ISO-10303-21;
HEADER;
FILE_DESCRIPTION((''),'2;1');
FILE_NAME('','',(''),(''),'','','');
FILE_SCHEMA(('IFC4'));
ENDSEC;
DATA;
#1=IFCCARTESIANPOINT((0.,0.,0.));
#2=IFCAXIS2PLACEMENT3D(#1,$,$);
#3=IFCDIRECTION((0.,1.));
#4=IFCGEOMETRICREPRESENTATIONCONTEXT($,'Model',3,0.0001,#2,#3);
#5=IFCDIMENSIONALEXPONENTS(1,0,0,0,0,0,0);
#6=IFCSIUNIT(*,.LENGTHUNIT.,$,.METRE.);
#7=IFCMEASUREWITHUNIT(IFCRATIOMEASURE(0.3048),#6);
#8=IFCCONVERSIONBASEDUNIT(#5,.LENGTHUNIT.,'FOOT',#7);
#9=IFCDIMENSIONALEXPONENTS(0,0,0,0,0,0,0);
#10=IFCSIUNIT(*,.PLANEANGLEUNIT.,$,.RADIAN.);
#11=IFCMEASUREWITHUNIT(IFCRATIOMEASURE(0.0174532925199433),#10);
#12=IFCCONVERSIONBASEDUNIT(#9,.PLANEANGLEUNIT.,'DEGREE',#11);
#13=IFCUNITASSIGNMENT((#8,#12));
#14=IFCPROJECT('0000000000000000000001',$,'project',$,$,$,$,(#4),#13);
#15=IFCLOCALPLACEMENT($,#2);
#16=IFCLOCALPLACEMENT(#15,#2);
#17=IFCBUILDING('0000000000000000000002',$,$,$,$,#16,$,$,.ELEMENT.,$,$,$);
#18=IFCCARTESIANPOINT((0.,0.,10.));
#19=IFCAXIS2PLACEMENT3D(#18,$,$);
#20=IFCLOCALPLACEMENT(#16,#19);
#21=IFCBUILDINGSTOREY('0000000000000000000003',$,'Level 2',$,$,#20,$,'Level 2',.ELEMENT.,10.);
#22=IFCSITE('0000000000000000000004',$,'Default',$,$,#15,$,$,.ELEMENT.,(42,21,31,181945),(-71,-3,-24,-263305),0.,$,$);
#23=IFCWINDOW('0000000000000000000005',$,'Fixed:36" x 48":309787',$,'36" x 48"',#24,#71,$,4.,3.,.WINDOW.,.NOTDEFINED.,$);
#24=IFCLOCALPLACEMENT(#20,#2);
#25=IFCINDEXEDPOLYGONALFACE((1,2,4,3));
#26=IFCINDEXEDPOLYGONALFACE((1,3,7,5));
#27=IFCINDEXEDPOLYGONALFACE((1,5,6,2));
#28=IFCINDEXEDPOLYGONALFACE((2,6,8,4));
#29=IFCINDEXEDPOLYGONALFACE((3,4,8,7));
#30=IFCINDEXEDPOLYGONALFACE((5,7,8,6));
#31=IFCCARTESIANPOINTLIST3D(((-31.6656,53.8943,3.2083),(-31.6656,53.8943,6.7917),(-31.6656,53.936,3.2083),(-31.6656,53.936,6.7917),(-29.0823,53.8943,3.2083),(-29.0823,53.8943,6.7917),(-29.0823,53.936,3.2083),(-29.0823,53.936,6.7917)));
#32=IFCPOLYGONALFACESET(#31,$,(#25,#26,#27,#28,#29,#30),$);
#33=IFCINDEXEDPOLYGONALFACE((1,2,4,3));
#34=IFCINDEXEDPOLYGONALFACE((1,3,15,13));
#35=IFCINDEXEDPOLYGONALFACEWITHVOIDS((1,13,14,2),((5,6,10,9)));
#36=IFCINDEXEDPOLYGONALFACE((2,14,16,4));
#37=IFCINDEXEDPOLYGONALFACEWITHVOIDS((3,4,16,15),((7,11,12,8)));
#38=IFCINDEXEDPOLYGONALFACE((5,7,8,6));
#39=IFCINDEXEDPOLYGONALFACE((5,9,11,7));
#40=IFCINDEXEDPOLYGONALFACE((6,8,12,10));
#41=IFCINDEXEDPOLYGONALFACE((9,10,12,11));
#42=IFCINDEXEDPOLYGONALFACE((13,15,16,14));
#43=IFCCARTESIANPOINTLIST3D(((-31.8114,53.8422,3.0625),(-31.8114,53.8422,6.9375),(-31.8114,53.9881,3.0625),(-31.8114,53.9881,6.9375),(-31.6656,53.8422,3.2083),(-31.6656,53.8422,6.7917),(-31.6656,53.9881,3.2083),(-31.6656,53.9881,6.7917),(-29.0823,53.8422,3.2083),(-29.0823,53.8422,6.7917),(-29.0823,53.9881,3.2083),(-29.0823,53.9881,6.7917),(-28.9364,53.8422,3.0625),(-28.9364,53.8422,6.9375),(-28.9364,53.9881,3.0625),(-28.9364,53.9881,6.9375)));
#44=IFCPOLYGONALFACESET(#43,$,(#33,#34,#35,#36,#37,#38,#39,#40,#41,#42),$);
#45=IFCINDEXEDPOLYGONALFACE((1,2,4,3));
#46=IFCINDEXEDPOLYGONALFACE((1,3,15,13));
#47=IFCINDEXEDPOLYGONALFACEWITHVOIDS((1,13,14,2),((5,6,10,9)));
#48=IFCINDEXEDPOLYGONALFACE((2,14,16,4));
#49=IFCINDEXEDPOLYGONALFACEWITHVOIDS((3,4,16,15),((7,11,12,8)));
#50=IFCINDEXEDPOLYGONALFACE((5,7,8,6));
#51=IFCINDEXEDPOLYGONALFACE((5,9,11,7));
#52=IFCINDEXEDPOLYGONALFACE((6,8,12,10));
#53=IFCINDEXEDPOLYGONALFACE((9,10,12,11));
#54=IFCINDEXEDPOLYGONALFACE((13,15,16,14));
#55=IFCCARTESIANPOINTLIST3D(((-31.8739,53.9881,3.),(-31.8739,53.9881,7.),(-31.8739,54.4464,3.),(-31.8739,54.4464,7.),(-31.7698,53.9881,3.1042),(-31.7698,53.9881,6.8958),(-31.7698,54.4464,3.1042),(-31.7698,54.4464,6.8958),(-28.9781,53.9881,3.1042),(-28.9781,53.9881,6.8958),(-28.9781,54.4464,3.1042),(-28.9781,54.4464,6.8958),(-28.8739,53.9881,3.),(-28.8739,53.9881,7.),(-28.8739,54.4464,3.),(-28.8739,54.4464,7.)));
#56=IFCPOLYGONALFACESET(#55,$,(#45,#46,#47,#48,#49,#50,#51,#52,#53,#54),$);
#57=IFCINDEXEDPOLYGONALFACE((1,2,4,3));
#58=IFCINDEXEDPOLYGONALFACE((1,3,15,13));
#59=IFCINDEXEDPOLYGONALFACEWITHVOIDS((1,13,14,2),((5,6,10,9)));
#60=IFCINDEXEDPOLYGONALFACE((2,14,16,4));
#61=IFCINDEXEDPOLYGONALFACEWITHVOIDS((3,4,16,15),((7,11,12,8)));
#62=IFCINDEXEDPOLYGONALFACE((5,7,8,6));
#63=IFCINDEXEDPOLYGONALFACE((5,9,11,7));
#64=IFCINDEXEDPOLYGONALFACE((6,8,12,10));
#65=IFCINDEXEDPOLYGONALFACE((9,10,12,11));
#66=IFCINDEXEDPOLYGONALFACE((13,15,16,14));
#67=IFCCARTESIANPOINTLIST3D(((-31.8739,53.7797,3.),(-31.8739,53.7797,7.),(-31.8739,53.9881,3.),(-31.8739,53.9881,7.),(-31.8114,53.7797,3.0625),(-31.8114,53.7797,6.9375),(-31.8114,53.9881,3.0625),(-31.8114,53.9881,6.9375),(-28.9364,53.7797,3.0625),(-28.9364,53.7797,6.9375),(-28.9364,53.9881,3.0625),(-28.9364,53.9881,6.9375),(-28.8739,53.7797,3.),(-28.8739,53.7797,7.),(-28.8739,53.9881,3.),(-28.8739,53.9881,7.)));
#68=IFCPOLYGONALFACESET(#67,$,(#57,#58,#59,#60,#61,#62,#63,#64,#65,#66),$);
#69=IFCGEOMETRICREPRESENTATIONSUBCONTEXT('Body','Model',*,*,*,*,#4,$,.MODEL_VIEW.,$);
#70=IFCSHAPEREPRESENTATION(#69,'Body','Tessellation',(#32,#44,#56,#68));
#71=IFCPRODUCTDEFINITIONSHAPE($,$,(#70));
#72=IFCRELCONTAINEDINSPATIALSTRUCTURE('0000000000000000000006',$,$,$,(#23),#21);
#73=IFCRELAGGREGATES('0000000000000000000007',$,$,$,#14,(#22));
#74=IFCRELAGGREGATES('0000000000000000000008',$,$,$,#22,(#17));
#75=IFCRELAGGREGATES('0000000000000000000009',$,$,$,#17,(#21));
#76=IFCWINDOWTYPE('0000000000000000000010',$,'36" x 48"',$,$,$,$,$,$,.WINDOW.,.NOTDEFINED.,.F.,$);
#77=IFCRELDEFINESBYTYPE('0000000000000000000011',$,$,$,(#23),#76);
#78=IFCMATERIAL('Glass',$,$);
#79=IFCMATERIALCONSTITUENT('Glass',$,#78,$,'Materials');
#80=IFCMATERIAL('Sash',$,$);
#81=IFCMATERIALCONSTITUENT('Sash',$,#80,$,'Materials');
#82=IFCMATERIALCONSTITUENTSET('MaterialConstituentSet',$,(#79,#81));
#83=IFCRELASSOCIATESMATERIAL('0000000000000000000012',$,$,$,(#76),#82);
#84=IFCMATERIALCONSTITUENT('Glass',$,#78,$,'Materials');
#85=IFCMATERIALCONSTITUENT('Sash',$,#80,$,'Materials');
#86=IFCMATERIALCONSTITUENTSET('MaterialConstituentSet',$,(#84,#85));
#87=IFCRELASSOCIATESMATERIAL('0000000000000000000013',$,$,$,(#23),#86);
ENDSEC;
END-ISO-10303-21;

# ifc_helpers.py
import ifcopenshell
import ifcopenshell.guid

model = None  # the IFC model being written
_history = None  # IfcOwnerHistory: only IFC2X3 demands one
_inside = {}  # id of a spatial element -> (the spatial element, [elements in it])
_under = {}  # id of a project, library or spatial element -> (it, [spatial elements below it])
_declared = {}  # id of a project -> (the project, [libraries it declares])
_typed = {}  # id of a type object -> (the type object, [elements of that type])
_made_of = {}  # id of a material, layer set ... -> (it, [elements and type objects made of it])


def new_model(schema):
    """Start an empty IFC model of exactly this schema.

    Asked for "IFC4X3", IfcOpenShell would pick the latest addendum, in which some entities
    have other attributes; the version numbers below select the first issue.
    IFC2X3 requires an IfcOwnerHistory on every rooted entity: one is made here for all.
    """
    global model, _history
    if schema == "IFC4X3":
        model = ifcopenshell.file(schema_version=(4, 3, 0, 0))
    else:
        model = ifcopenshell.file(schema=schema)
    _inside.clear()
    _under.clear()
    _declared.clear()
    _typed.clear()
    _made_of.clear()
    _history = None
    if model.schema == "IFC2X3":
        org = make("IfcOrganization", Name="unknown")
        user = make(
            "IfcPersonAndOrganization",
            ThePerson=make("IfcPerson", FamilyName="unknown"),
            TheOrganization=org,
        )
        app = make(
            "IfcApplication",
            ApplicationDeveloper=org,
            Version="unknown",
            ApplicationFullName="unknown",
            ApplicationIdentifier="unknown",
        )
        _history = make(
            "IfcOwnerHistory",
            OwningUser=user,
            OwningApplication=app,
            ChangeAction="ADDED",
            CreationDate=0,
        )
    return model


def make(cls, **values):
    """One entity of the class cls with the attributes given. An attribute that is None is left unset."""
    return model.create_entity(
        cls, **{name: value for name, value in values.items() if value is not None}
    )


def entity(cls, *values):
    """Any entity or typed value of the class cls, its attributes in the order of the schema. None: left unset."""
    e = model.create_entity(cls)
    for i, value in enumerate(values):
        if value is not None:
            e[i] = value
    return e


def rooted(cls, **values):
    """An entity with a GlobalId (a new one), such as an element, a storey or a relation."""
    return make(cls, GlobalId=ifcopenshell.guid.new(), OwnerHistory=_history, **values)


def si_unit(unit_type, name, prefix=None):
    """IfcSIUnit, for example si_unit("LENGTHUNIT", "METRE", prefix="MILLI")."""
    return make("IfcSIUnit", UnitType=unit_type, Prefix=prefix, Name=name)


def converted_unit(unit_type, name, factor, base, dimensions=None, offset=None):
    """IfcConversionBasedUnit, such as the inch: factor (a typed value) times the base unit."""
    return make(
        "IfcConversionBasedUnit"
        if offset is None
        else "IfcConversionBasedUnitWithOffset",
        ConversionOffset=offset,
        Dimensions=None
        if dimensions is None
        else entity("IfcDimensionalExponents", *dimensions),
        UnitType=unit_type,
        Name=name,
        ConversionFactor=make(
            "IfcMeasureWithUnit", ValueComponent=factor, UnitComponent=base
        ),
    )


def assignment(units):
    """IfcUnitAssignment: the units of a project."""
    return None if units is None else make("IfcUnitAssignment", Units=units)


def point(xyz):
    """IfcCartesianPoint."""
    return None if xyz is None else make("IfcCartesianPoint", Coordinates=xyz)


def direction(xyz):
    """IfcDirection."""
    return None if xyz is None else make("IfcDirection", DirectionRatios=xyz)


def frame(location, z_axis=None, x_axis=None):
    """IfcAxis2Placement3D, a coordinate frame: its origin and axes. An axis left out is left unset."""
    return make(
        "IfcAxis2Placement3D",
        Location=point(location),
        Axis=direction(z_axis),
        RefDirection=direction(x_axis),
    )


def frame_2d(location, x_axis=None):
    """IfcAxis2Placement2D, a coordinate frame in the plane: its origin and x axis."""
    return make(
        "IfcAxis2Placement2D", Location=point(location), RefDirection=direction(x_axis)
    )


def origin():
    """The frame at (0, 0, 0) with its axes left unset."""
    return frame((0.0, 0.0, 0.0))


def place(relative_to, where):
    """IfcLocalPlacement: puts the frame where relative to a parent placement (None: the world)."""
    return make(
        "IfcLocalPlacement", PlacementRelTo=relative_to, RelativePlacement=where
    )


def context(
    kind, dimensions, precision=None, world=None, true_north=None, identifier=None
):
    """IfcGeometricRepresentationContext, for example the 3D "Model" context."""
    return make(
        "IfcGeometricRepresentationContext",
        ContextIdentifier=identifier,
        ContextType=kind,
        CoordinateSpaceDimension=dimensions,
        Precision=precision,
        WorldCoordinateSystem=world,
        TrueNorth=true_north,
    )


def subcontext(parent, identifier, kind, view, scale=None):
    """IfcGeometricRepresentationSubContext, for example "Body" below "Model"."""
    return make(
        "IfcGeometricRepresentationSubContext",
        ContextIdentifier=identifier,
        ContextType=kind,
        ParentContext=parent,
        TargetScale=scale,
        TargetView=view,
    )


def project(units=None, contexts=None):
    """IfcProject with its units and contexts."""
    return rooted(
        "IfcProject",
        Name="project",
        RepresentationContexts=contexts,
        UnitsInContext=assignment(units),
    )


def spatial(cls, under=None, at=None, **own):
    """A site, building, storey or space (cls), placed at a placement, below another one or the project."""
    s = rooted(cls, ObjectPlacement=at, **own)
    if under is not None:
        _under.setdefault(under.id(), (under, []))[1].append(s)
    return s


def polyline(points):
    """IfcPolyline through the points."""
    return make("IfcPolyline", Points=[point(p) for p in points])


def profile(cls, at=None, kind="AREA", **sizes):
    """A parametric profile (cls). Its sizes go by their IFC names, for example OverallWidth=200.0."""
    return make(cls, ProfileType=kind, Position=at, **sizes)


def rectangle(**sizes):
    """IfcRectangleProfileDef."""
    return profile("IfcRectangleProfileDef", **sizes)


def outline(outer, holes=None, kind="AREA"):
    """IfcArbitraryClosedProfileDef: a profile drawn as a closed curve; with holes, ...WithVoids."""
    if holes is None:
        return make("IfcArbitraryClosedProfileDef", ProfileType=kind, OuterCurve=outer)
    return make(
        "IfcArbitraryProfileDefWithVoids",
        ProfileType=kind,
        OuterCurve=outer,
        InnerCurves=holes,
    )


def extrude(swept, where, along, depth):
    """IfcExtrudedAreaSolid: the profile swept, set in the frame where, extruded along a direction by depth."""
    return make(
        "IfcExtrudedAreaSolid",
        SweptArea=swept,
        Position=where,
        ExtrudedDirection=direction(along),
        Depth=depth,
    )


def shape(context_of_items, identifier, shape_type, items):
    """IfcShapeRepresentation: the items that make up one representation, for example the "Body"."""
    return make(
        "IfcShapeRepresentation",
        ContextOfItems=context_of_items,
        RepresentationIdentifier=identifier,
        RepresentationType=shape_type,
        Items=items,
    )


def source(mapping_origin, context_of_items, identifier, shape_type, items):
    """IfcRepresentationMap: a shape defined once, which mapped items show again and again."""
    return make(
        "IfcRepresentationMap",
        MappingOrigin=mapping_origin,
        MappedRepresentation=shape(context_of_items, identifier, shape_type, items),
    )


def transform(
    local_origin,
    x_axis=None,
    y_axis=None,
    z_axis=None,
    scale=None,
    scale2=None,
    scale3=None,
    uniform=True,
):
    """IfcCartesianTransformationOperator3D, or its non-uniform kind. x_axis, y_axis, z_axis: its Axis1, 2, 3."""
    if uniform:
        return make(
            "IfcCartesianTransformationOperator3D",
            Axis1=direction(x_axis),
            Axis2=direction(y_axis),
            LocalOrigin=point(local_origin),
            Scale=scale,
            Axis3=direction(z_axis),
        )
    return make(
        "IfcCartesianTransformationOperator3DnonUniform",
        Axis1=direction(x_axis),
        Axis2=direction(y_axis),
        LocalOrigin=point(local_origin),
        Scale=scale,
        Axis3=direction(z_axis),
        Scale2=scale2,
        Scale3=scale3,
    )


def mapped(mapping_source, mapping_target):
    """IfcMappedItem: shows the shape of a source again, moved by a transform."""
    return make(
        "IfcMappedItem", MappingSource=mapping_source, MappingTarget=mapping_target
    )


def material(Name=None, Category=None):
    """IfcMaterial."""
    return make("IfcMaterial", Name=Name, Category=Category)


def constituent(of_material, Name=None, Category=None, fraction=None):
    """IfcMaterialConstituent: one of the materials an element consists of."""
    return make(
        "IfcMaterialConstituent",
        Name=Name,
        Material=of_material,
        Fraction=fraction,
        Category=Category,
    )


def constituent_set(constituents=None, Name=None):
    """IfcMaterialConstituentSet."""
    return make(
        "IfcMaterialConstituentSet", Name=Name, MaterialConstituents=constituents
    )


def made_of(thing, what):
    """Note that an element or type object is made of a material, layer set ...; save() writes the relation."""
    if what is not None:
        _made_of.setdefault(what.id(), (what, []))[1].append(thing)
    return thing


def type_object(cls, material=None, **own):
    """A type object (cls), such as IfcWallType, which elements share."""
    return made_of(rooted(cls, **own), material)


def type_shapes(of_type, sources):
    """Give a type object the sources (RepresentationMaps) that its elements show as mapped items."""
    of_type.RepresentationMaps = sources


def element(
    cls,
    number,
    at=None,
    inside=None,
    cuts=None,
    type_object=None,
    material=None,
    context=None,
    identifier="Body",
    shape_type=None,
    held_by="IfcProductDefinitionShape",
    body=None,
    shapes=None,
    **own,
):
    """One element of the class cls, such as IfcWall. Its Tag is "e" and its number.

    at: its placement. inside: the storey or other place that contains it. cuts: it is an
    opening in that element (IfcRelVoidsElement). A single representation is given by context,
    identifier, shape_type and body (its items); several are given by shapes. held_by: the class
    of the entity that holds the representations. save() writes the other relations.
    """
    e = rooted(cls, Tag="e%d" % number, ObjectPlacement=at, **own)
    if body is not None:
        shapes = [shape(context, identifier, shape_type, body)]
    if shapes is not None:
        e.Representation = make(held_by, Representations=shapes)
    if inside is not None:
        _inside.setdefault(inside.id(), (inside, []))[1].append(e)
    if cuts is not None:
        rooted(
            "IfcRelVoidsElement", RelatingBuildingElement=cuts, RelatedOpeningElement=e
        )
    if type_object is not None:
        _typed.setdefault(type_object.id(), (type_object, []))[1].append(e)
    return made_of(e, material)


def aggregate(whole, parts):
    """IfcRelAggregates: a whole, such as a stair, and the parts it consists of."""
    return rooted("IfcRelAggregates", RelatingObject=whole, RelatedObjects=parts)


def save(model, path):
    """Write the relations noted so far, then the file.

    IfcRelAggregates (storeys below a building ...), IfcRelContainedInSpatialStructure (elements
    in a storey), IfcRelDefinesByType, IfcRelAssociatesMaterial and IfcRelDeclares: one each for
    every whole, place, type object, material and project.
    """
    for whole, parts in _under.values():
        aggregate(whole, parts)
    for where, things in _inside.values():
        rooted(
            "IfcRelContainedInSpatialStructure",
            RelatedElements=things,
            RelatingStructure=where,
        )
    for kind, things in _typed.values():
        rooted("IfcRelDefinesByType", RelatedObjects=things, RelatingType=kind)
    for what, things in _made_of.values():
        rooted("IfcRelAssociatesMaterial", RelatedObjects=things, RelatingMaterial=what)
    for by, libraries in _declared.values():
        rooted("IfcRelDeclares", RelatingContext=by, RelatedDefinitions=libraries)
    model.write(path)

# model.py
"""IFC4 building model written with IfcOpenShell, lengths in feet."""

from ifc_helpers import new_model, entity, si_unit, converted_unit, direction, frame, frame_2d, origin, place, context, subcontext, project, spatial, polyline, rectangle, outline, extrude, source, transform, mapped, material, constituent, constituent_set, type_object, type_shapes, element, save


model = new_model("IFC4")

# Units and contexts
model_context = context("Model", 3, precision=0.0001, world=origin(), true_north=direction((0.0, 1.0)))
body_context = subcontext(model_context, "Body", "Model", "MODEL_VIEW")
ifc_project = project(units=[converted_unit("LENGTHUNIT", "FOOT", entity("IfcRatioMeasure", 0.3048), si_unit("LENGTHUNIT", "METRE"), dimensions=[1, 0, 0, 0, 0, 0, 0]), converted_unit("PLANEANGLEUNIT", "DEGREE", entity("IfcRatioMeasure", 0.0174532925199433), si_unit("PLANEANGLEUNIT", "RADIAN"), dimensions=[0, 0, 0, 0, 0, 0, 0])], contexts=[model_context])

# Site, building, storey
site_placement = place(None, origin())
site = spatial("IfcSite", under=ifc_project, at=site_placement, Name="Default", CompositionType="ELEMENT", RefLatitude=(42, 21, 31, 181945), RefLongitude=(-71, -3, -24, -263305), RefElevation=0.0)
building_placement = place(site_placement, origin())
building = spatial("IfcBuilding", under=site, at=building_placement, CompositionType="ELEMENT")
storey_placement = place(building_placement, frame((0.0, 0.0, 10.0)))
storey = spatial("IfcBuildingStorey", under=building, at=storey_placement, Name="Level 2", LongName="Level 2", CompositionType="ELEMENT", Elevation=10.0)

# Shared definitions
placement_1 = place(storey_placement, frame((-39.4573, 54.1131, 0.0)))

# Window
ifc_material_1 = material(Name="Glass")
ifc_constituent_1 = constituent(ifc_material_1, Name="Glass", Category="Materials")
ifc_material_2 = material(Name="Sash")
ifc_constituent_2 = constituent(ifc_material_2, Name="Sash", Category="Materials")
ifc_constituent_set_1 = constituent_set(constituents=[ifc_constituent_1, ifc_constituent_2], Name="MaterialConstituentSet")
ifc_constituent_3 = constituent(ifc_material_1, Name="Glass", Category="Materials")
ifc_constituent_4 = constituent(ifc_material_2, Name="Sash", Category="Materials")
ifc_constituent_set_2 = constituent_set(constituents=[ifc_constituent_3, ifc_constituent_4], Name="MaterialConstituentSet")
window_type = type_object("IfcWindowType", Name="36\" x 48\"", ParameterTakesPrecedence=False, PartitioningType="NOTDEFINED", PredefinedType="WINDOW", material=ifc_constituent_set_2)
shared_shape = source(origin(), body_context, "Body", "SweptSolid", [
    extrude(rectangle(XDim=0.0417, YDim=2.5833, at=frame_2d((0.0, 0.0), x_axis=(1.0, 0.0))), frame((1.5, 0.5312, 0.2083), z_axis=(0.0, 0.0, 1.0), x_axis=(0.0, 1.0, 0.0)), (0.0, 0.0, 1.0), 3.5833),
    extrude(outline(polyline([(-1.4375, -1.9375), (1.4375, -1.9375), (1.4375, 1.9375), (-1.4375, 1.9375), (-1.4375, -1.9375)]), holes=[polyline([(-1.2917, -1.7917), (-1.2917, 1.7917), (1.2917, 1.7917), (1.2917, -1.7917), (-1.2917, -1.7917)])]), frame((1.5, 0.4583, 2.0), z_axis=(0.0, 1.0, 0.0), x_axis=(1.0, 0.0, 0.0)), (0.0, 0.0, 1.0), 0.1458),
    extrude(outline(polyline([(-1.5, -2.0), (1.5, -2.0), (1.5, 2.0), (-1.5, 2.0), (-1.5, -2.0)]), holes=[polyline([(-1.3958, -1.8958), (-1.3958, 1.8958), (1.3958, 1.8958), (1.3958, -1.8958), (-1.3958, -1.8958)])]), frame((1.5, 0.0, 2.0), z_axis=(0.0, 1.0, 0.0), x_axis=(1.0, 0.0, 0.0)), (0.0, 0.0, 1.0), 0.4583),
    extrude(outline(polyline([(-2.0, -1.5), (2.0, -1.5), (2.0, 1.5), (-2.0, 1.5), (-2.0, -1.5)]), holes=[polyline([(-1.9375, -1.4375), (-1.9375, 1.4375), (1.9375, 1.4375), (1.9375, -1.4375), (-1.9375, -1.4375)])]), frame((1.5, 0.4583, 2.0), z_axis=(0.0, 1.0, 0.0), x_axis=(0.0, 0.0, -1.0)), (0.0, 0.0, 1.0), 0.2083),
])
type_shapes(window_type, [shared_shape])
placement_2 = place(placement_1, frame((10.5833, 0.3333, 3.0)))
window_placement = place(placement_2, frame((0.0, 0.0, 0.0), z_axis=(0.0, 0.0, 1.0), x_axis=(-1.0, 0.0, 0.0)))
element("IfcWindow", 1, at=window_placement, inside=storey, type_object=window_type, material=ifc_constituent_set_1, Name="Fixed:36\" x 48\":309787", ObjectType="36\" x 48\"", OverallHeight=4.0, OverallWidth=3.0, PartitioningType="NOTDEFINED", PredefinedType="WINDOW", context=body_context, shape_type="MappedRepresentation", body=[
    mapped(shared_shape, transform((0.0, 0.0, 0.0), scale=1.0)),
])

save(model, "model.ifc")
